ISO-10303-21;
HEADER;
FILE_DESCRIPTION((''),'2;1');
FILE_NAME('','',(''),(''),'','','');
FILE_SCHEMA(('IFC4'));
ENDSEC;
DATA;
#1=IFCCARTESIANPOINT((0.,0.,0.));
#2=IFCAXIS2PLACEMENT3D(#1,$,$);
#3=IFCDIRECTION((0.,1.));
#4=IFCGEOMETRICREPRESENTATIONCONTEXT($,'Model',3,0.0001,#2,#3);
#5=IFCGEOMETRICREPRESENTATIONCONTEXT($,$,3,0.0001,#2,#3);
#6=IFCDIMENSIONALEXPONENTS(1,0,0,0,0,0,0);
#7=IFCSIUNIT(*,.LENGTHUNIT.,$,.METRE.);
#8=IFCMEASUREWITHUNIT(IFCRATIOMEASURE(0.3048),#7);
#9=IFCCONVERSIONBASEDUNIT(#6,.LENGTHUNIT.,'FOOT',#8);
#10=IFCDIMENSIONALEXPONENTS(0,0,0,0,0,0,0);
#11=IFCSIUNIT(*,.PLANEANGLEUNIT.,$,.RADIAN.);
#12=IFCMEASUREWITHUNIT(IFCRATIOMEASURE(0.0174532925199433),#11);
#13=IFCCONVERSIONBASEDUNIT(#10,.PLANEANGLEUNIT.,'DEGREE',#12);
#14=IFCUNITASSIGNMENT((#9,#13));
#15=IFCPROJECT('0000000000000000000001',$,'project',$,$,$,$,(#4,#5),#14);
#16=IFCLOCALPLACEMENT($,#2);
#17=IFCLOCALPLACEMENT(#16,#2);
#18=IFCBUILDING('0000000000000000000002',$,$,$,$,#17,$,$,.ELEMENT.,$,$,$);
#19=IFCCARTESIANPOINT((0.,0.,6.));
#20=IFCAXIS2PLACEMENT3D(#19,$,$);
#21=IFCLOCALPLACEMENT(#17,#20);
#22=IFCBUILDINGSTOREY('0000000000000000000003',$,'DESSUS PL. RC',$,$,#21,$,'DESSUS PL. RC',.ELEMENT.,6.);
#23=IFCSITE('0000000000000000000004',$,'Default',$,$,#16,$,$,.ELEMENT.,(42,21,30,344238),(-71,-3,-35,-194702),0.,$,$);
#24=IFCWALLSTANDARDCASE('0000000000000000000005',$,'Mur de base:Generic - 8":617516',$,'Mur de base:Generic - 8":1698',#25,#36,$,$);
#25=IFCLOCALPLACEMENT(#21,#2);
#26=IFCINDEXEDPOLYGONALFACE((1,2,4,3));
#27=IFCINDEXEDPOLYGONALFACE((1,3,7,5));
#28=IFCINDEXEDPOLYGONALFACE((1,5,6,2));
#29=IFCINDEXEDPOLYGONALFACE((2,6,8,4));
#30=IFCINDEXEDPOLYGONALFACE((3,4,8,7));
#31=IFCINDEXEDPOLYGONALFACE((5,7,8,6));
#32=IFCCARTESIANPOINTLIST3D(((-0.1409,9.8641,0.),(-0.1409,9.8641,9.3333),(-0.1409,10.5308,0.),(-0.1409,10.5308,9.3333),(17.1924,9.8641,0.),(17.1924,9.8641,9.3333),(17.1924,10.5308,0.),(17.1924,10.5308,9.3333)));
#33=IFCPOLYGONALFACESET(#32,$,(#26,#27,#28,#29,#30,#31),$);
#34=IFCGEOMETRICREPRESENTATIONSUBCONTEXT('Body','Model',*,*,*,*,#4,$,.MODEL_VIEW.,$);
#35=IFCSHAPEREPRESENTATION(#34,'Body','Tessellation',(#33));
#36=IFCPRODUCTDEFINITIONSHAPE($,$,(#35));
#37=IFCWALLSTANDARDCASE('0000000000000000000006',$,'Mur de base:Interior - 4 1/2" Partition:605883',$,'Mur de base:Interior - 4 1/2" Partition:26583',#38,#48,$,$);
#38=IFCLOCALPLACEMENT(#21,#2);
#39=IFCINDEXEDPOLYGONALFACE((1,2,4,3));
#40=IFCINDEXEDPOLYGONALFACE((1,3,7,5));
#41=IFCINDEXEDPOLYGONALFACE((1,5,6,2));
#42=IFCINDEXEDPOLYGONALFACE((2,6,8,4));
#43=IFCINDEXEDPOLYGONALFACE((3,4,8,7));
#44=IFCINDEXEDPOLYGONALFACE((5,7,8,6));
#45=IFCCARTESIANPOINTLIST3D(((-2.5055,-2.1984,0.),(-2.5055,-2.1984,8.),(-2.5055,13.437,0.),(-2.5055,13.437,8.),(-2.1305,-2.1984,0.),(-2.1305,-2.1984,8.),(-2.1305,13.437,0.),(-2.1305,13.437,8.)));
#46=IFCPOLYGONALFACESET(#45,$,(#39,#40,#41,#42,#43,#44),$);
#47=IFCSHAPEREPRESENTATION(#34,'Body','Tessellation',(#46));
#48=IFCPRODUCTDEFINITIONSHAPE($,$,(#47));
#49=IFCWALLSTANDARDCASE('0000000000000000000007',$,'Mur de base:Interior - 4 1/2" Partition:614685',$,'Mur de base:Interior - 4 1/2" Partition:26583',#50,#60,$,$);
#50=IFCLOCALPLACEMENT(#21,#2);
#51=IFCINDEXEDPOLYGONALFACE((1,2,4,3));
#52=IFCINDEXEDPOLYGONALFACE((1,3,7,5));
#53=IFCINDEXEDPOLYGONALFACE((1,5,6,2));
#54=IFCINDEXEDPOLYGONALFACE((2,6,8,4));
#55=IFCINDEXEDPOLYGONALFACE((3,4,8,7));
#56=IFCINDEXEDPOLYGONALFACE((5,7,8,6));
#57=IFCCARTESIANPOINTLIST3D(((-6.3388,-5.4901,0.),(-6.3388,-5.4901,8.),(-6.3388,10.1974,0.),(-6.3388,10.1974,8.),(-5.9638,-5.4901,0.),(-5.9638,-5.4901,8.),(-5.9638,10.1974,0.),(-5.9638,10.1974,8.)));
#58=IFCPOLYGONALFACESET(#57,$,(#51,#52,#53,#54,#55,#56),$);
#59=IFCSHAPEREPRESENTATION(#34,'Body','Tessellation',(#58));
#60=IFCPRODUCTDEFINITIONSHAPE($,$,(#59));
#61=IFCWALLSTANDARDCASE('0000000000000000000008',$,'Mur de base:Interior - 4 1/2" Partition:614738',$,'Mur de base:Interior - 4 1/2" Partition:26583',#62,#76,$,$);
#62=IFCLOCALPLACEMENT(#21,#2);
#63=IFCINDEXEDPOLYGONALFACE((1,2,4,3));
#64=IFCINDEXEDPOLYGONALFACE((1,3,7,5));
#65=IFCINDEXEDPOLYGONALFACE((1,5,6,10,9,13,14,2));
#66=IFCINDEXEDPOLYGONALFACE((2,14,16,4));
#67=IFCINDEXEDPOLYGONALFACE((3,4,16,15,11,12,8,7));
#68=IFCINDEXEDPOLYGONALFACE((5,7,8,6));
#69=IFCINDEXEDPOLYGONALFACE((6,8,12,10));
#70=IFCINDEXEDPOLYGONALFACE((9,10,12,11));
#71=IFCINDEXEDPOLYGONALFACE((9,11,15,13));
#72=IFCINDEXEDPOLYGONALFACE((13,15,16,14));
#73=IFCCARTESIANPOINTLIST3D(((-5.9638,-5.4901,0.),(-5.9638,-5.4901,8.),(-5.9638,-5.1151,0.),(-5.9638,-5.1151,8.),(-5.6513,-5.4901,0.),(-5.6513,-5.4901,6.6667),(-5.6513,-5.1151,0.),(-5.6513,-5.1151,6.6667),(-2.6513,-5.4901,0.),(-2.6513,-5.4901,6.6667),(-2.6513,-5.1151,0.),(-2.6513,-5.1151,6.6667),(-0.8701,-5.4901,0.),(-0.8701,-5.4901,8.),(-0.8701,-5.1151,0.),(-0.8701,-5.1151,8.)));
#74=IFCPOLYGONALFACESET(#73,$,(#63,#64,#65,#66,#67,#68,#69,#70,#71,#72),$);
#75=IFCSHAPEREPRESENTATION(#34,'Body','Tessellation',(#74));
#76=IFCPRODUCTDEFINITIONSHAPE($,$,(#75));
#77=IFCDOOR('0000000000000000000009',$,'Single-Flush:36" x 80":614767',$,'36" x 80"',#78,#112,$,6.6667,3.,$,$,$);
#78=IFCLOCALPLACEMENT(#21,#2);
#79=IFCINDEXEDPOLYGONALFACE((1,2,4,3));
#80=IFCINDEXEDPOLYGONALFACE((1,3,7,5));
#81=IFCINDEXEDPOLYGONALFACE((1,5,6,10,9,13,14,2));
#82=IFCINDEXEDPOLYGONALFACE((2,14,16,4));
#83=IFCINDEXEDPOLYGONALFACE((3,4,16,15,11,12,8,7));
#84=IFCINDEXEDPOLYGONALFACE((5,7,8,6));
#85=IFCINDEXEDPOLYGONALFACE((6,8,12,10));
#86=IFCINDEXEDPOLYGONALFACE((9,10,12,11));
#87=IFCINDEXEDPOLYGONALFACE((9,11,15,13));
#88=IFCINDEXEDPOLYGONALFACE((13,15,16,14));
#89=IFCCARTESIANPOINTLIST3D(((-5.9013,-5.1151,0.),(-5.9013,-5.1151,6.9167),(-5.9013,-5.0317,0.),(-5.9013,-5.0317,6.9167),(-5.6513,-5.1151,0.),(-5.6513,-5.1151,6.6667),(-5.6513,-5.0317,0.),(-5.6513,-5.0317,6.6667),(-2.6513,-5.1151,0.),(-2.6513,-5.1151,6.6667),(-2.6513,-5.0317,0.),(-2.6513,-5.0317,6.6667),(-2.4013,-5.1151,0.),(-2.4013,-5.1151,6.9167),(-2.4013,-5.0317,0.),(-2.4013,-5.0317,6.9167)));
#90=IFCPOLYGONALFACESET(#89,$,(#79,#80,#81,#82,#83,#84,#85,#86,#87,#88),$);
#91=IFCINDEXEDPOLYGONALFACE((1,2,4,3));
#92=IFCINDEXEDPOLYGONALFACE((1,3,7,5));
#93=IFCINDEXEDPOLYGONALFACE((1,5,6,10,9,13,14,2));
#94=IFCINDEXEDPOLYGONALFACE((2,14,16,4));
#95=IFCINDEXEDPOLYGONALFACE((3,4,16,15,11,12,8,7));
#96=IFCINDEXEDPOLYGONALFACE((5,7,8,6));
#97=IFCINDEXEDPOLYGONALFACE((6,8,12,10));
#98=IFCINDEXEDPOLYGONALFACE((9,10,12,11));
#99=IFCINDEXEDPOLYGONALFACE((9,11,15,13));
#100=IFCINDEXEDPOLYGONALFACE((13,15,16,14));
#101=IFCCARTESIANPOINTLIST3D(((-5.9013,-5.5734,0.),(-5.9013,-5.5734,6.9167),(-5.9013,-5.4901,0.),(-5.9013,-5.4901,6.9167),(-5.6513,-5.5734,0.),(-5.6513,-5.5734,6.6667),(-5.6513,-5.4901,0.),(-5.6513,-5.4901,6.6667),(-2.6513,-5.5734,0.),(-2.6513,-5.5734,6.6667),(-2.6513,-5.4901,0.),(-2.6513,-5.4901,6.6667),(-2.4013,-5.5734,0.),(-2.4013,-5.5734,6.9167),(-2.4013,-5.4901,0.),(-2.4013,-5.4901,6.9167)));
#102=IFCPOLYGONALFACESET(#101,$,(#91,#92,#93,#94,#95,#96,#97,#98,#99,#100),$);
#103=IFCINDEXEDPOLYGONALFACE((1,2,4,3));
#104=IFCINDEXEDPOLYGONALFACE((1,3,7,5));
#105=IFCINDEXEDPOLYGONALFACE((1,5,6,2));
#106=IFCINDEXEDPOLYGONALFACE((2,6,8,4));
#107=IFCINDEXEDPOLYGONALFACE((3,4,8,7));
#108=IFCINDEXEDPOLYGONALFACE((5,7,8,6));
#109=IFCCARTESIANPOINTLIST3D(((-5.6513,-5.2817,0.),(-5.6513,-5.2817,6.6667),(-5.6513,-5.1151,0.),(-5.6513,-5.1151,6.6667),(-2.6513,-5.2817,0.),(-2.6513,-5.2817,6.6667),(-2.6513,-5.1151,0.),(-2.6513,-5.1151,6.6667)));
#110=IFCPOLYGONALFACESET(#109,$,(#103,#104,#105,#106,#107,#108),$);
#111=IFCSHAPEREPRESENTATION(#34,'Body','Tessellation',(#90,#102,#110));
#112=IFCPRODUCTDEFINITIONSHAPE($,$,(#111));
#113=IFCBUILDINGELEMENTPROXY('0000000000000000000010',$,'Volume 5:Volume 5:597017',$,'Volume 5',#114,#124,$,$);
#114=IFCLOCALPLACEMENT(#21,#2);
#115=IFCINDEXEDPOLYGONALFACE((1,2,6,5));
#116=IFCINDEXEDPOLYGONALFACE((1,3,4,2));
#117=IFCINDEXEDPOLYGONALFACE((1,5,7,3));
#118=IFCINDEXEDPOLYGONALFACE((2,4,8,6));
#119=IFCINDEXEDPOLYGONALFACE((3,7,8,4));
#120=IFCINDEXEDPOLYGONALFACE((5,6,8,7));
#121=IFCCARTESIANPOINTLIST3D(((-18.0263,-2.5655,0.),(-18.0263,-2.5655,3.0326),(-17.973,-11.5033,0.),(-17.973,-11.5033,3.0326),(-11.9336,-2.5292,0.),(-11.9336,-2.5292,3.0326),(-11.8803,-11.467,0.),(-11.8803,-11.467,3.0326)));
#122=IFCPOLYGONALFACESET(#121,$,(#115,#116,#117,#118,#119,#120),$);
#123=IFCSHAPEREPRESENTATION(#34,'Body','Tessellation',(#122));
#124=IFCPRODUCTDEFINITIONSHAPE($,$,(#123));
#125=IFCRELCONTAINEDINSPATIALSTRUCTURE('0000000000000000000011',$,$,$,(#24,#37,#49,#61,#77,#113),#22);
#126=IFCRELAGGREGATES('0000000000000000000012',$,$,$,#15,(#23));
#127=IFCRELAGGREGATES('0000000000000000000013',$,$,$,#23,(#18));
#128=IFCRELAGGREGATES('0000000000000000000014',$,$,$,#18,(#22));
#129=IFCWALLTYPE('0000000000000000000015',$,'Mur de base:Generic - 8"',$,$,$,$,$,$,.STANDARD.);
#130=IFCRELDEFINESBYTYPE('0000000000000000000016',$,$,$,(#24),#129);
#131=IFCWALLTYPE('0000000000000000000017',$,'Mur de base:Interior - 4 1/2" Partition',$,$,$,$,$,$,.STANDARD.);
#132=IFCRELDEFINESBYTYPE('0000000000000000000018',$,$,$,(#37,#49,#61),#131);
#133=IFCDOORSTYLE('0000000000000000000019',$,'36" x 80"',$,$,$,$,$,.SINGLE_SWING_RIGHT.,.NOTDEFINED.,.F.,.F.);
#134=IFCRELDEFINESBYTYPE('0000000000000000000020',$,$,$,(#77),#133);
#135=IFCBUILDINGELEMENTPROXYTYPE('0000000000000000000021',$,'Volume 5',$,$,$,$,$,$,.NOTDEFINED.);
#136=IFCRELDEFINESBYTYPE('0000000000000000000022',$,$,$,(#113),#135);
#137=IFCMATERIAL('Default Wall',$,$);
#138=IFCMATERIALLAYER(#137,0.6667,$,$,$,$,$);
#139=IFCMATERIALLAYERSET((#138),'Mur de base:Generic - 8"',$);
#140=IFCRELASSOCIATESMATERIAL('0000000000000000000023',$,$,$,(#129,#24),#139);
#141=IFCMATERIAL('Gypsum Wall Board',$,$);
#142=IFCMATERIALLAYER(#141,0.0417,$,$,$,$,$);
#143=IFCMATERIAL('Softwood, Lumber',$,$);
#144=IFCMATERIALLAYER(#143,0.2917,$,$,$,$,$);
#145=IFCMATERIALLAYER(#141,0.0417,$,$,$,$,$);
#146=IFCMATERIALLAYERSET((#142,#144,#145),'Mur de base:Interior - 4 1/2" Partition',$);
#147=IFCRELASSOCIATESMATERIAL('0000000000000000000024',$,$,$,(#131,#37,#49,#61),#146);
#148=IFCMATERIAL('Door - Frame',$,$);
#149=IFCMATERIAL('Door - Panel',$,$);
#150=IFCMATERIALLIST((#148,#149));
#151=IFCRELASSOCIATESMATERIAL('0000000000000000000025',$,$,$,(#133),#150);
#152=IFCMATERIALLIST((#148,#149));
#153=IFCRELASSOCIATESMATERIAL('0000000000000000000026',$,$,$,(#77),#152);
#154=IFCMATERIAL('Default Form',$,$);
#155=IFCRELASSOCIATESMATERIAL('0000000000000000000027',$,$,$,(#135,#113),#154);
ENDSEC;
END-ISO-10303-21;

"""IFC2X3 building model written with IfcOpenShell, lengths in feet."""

from ifc_helpers import new_model, entity, si_unit, converted_unit, direction, frame, frame_2d, origin, place, context, subcontext, project, spatial, polyline, rectangle, outline, extrude, source, transform, mapped, material, material_list, layer, layer_set, layer_usage, type_object, type_shapes, element, fill, save


model = new_model("IFC2X3")

# Units and contexts
model_context = context("Model", 3, precision=0.0001, world=origin(), true_north=direction((0.0, 1.0)))
context_of_model = context(None, 3, precision=0.0001, world=origin(), true_north=direction((0.0, 1.0)))
body_context = subcontext(model_context, "Body", "Model", "MODEL_VIEW")
ifc_project = project(units=[converted_unit("LENGTHUNIT", "FOOT", entity("IfcRatioMeasure", 0.3048), si_unit("LENGTHUNIT", "METRE"), dimensions=[1, 0, 0, 0, 0, 0, 0]), converted_unit("PLANEANGLEUNIT", "DEGREE", entity("IfcRatioMeasure", 0.0174532925199433), si_unit("PLANEANGLEUNIT", "RADIAN"), dimensions=[0, 0, 0, 0, 0, 0, 0])], contexts=[model_context, context_of_model])

# Site, building, storey
site_placement = place(None, origin())
site = spatial("IfcSite", under=ifc_project, at=site_placement, Name="Default", CompositionType="ELEMENT", RefLatitude=(42, 21, 30, 344238), RefLongitude=(-71, -3, -35, -194702), RefElevation=0.0)
building_placement = place(site_placement, origin())
building = spatial("IfcBuilding", under=site, at=building_placement, CompositionType="ELEMENT")
storey_placement = place(building_placement, frame((0.0, 0.0, 6.0)))
storey = spatial("IfcBuildingStorey", under=building, at=storey_placement, Name="DESSUS PL. RC", LongName="DESSUS PL. RC", CompositionType="ELEMENT", Elevation=6.0)

# Shared definitions
ifc_material_1 = material(Name="Default Wall")
ifc_material_2 = material(Name="Softwood, Lumber")
ifc_material_3 = material(Name="Gypsum Wall Board")
ifc_material_4 = material(Name="Door - Frame")
ifc_material_5 = material(Name="Door - Panel")

# Shared definitions
ifc_layer_1 = layer(ifc_material_1, 0.6667)
ifc_layer_set_1 = layer_set([ifc_layer_1], Name="Mur de base:Generic - 8\"")
wall_type_1 = type_object("IfcWallType", Name="Mur de base:Generic - 8\"", PredefinedType="STANDARD", material=ifc_layer_set_1)

# Walls
ifc_layer_usage_1 = layer_usage(ifc_layer_set_1, "AXIS2", "NEGATIVE", 0.3333)
wall_1_placement = place(storey_placement, frame((17.1924, 10.1974, 0.0), z_axis=(0.0, 0.0, 1.0), x_axis=(-1.0, 0.0, 0.0)))
element("IfcWallStandardCase", 1, at=wall_1_placement, inside=storey, type_object=wall_type_1, material=ifc_layer_usage_1, Name="Mur de base:Generic - 8\":617516", ObjectType="Mur de base:Generic - 8\":1698", context=body_context, shape_type="SweptSolid", body=[
    extrude(rectangle(XDim=17.3333, YDim=0.6667, at=frame_2d((8.6667, 0.0), x_axis=(-1.0, 0.0))), origin(), (0.0, 0.0, 1.0), 9.3333),
])
ifc_layer_2 = layer(ifc_material_3, 0.0417)
ifc_layer_3 = layer(ifc_material_2, 0.2917)
ifc_layer_4 = layer(ifc_material_3, 0.0417)
ifc_layer_set_2 = layer_set([ifc_layer_2, ifc_layer_3, ifc_layer_4], Name="Mur de base:Interior - 4 1/2\" Partition")
ifc_layer_usage_2 = layer_usage(ifc_layer_set_2, "AXIS2", "NEGATIVE", 0.1875)
wall_type_2 = type_object("IfcWallType", Name="Mur de base:Interior - 4 1/2\" Partition", PredefinedType="STANDARD", material=ifc_layer_set_2)
wall_2_placement = place(storey_placement, frame((-2.318, 13.437, 0.0), z_axis=(0.0, 0.0, 1.0), x_axis=(0.0, -1.0, 0.0)))
element("IfcWallStandardCase", 2, at=wall_2_placement, inside=storey, type_object=wall_type_2, material=ifc_layer_usage_2, Name="Mur de base:Interior - 4 1/2\" Partition:605883", ObjectType="Mur de base:Interior - 4 1/2\" Partition:26583", context=body_context, shape_type="SweptSolid", body=[
    extrude(rectangle(XDim=15.6354, YDim=0.375, at=frame_2d((7.8177, 0.0), x_axis=(-1.0, 0.0))), origin(), (0.0, 0.0, 1.0), 8.0),
])

# Wall
ifc_layer_usage_3 = layer_usage(ifc_layer_set_2, "AXIS2", "NEGATIVE", 0.1875)
wall_3_placement = place(storey_placement, frame((-6.1513, 10.1974, 0.0), z_axis=(0.0, 0.0, 1.0), x_axis=(0.0, -1.0, 0.0)))
element("IfcWallStandardCase", 3, at=wall_3_placement, inside=storey, type_object=wall_type_2, material=ifc_layer_usage_3, Name="Mur de base:Interior - 4 1/2\" Partition:614685", ObjectType="Mur de base:Interior - 4 1/2\" Partition:26583", context=body_context, shape_type="SweptSolid", body=[
    extrude(rectangle(XDim=15.6875, YDim=0.375, at=frame_2d((7.8438, 0.0), x_axis=(-1.0, 0.0))), origin(), (0.0, 0.0, 1.0), 8.0),
])

# Wall, opening, door
ifc_layer_usage_4 = layer_usage(ifc_layer_set_2, "AXIS2", "NEGATIVE", 0.1875)
wall_4_placement = place(storey_placement, frame((-5.9638, -5.3026, 0.0)))
wall_4 = element("IfcWallStandardCase", 4, at=wall_4_placement, inside=storey, type_object=wall_type_2, material=ifc_layer_usage_4, Name="Mur de base:Interior - 4 1/2\" Partition:614738", ObjectType="Mur de base:Interior - 4 1/2\" Partition:26583", context=body_context, shape_type="SweptSolid", body=[
    extrude(rectangle(XDim=5.0938, YDim=0.375, at=frame_2d((2.5469, 0.0), x_axis=(-1.0, 0.0))), origin(), (0.0, 0.0, 1.0), 8.0),
])
opening_1_placement = place(wall_4_placement, frame((0.3125, -0.1875, 0.0)))
opening_1 = element("IfcOpeningElement", 5, at=opening_1_placement, cuts=wall_4, ObjectType="Opening", context=body_context, shape_type="SweptSolid", body=[
    extrude(rectangle(XDim=3.0, YDim=6.6667, at=frame_2d((3.3333, 1.5), x_axis=(0.0, 1.0))), frame((0.0, 0.0, 0.0), z_axis=(0.0, 1.0, 0.0), x_axis=(0.0, 0.0, 1.0)), (0.0, 0.0, 1.0), 0.375),
])
ifc_material_list_1 = material_list([ifc_material_4, ifc_material_5])
ifc_material_list_2 = material_list([ifc_material_4, ifc_material_5])
door_style_1 = type_object("IfcDoorStyle", Name="36\" x 80\"", ConstructionType="NOTDEFINED", OperationType="SINGLE_SWING_RIGHT", ParameterTakesPrecedence=False, Sizeable=False, material=ifc_material_list_2)
shared_shape_1 = source(origin(), body_context, "Body", "SweptSolid", [
    extrude(outline(polyline([(-1.75, -3.5208), (1.75, -3.5208), (1.75, 3.3958), (1.5, 3.3958), (1.5, -3.2708), (-1.5, -3.2708), (-1.5, 3.3958), (-1.75, 3.3958), (-1.75, -3.5208)])), frame((1.5, 0.375, 3.3958), z_axis=(0.0, 1.0, 0.0), x_axis=(1.0, 0.0, 0.0)), (0.0, 0.0, 1.0), 0.0833),
    extrude(outline(polyline([(-3.5208, -1.75), (3.3958, -1.75), (3.3958, -1.5), (-3.2708, -1.5), (-3.2708, 1.5), (3.3958, 1.5), (3.3958, 1.75), (-3.5208, 1.75), (-3.5208, -1.75)])), frame((1.5, -0.0833, 3.3958), z_axis=(0.0, 1.0, 0.0), x_axis=(0.0, 0.0, -1.0)), (0.0, 0.0, 1.0), 0.0833),
    extrude(rectangle(XDim=0.1667, YDim=3.0, at=frame_2d((0.0, 0.0), x_axis=(1.0, 0.0))), frame((1.5, 0.2917, 0.0), z_axis=(0.0, 0.0, 1.0), x_axis=(0.0, 1.0, 0.0)), (0.0, 0.0, 1.0), 6.6667),
])
type_shapes(door_style_1, [shared_shape_1])
door_1_placement = place(opening_1_placement, origin())
door_1 = element("IfcDoor", 6, at=door_1_placement, inside=storey, type_object=door_style_1, material=ifc_material_list_1, Name="Single-Flush:36\" x 80\":614767", ObjectType="36\" x 80\"", OverallHeight=6.6667, OverallWidth=3.0, context=body_context, shape_type="MappedRepresentation", body=[
    mapped(shared_shape_1, transform((0.0, 0.0, 0.0), scale=1.0)),
])
fill(opening_1, door_1)

# Building element proxy
ifc_material_6 = material(Name="Default Form")
building_element_proxy_type = type_object("IfcBuildingElementProxyType", Name="Volume 5", PredefinedType="NOTDEFINED", material=ifc_material_6)
shared_shape_2 = source(origin(), body_context, "Body", "SweptSolid", [
    extrude(rectangle(XDim=6.0928, YDim=8.9379, at=frame_2d((0.0, 0.0), x_axis=(1.0, 0.0))), frame((-14.9533, -7.0163, 6.0), z_axis=(0.0, 0.0, 1.0), x_axis=(0.999982, 0.005957, 0.0)), (0.0, 0.0, 1.0), 3.0326),
])
type_shapes(building_element_proxy_type, [shared_shape_2])
proxy_placement = place(storey_placement, frame((0.0, 0.0, -6.0)))
element("IfcBuildingElementProxy", 7, at=proxy_placement, inside=storey, type_object=building_element_proxy_type, material=ifc_material_6, Name="Volume 5:Volume 5:597017", ObjectType="Volume 5", context=body_context, shape_type="MappedRepresentation", body=[
    mapped(shared_shape_2, transform((0.0, 0.0, 0.0), scale=1.0)),
])

save(model, "model.ifc")
